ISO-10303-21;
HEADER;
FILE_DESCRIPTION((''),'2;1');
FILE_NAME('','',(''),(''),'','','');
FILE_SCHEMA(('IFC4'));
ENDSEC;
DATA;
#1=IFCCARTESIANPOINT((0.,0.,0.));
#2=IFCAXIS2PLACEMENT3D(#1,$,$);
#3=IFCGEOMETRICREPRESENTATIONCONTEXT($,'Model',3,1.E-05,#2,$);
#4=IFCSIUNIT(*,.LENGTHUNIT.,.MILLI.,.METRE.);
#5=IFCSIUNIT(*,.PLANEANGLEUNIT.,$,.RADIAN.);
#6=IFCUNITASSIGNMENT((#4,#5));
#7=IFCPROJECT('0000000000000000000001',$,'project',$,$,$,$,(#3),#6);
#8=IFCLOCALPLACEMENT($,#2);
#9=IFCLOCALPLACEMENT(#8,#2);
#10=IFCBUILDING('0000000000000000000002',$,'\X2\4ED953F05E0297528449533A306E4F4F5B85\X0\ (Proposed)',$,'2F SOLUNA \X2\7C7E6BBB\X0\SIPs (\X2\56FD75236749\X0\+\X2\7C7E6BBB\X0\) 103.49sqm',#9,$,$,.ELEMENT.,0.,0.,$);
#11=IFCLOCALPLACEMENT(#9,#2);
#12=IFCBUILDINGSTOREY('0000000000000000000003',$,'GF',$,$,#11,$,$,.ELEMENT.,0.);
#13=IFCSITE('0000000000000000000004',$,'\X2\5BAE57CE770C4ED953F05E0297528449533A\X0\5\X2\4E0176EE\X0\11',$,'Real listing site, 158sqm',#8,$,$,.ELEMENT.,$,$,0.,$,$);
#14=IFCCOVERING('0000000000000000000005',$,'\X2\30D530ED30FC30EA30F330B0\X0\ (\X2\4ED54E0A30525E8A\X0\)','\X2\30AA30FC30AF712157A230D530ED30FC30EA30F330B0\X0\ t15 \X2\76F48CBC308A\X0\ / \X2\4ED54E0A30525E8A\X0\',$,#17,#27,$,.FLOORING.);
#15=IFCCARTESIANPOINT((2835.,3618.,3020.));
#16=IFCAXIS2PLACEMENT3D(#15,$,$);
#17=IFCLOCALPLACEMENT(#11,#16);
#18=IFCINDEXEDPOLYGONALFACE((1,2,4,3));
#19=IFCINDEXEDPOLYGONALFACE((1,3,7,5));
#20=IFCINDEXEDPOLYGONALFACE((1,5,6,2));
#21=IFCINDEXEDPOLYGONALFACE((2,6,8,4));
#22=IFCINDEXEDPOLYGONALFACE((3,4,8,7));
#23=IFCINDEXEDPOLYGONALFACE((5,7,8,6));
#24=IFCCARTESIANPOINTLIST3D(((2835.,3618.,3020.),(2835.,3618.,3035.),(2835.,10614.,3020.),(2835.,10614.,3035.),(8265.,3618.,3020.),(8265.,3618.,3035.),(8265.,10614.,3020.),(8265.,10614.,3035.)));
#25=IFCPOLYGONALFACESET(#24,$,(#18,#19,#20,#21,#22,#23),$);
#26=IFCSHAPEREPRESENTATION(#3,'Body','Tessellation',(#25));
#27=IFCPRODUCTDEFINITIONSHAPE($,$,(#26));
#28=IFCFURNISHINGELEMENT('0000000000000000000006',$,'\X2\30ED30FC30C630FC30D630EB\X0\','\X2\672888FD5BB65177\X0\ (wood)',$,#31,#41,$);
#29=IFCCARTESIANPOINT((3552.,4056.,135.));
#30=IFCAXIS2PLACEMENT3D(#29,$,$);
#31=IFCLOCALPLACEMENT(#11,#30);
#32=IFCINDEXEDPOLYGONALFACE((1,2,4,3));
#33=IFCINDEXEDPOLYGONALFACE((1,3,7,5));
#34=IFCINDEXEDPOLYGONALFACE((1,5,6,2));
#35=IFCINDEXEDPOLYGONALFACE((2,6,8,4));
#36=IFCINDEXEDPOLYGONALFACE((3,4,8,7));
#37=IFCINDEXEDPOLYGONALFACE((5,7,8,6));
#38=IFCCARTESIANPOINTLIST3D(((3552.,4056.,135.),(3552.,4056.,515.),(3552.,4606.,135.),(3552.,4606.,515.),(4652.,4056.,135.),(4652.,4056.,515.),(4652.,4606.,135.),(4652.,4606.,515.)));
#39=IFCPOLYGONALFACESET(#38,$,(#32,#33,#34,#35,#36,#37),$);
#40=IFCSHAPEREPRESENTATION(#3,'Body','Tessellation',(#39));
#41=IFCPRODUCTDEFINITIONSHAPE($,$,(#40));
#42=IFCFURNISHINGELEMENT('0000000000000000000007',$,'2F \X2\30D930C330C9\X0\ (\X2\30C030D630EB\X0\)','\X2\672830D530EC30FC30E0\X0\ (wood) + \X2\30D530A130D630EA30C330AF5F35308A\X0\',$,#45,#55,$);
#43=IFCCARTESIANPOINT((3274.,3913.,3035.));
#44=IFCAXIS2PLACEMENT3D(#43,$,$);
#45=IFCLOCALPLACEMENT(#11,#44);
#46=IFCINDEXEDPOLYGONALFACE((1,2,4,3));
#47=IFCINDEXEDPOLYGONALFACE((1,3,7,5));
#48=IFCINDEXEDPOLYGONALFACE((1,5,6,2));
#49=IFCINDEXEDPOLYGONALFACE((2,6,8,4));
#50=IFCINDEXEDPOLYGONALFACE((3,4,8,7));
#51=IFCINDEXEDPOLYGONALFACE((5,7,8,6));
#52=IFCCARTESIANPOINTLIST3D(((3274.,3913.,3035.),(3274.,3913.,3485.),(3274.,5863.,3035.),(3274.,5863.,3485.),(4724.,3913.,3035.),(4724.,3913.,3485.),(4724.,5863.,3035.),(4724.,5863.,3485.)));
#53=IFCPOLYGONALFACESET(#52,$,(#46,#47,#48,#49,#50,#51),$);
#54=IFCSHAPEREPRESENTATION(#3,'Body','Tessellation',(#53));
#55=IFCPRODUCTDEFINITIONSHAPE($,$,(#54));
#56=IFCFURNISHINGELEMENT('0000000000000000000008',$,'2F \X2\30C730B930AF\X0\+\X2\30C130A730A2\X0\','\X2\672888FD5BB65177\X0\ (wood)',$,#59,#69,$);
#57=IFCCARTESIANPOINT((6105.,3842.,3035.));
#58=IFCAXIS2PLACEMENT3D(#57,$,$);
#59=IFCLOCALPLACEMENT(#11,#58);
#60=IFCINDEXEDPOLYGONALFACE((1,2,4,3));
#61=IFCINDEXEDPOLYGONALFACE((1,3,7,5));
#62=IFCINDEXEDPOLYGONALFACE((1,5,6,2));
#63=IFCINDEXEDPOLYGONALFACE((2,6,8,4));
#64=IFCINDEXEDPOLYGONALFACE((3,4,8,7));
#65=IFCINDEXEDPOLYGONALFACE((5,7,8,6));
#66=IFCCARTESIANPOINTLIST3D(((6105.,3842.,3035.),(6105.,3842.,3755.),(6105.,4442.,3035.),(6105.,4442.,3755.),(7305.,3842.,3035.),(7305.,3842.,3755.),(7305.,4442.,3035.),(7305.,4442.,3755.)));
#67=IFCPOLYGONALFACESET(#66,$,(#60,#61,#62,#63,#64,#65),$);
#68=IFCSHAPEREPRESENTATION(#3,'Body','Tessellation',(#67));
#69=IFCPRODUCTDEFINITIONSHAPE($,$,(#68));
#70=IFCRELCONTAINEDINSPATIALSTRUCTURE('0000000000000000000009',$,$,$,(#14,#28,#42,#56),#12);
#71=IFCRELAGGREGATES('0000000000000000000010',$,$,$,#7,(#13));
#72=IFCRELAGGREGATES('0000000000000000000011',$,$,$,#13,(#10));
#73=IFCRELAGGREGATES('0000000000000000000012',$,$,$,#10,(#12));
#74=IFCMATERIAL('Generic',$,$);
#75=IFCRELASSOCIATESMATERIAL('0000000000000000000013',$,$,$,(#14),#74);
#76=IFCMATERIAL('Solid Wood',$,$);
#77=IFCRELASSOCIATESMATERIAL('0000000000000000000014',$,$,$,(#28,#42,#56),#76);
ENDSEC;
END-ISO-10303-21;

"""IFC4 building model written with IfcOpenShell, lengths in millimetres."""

from ifc_helpers import new_model, si_unit, frame, frame_2d, origin, place, context, project, spatial, rectangle, extrude, material, element, save


model = new_model("IFC4")

# Units and contexts
model_context = context("Model", 3, precision=1e-05, world=origin())
ifc_project = project(units=[si_unit("LENGTHUNIT", "METRE", prefix="MILLI"), si_unit("PLANEANGLEUNIT", "RADIAN")], contexts=[model_context])

# Site, building, storey
site_placement = place(None, origin())
site = spatial("IfcSite", under=ifc_project, at=site_placement, Name="宮城県仙台市青葉区5丁目11", ObjectType="Real listing site, 158sqm", CompositionType="ELEMENT", RefElevation=0.0)
building_placement = place(site_placement, origin())
building = spatial("IfcBuilding", under=site, at=building_placement, Name="仙台市青葉区の住宅 (Proposed)", ObjectType="2F SOLUNA 籾殻SIPs (国産杉+籾殻) 103.49sqm", CompositionType="ELEMENT", ElevationOfRefHeight=0.0, ElevationOfTerrain=0.0)
storey_placement = place(building_placement, origin())
storey = spatial("IfcBuildingStorey", under=building, at=storey_placement, Name="GF", CompositionType="ELEMENT", Elevation=0.0)

# Shared definitions
ifc_material_1 = material(Name="Solid Wood")

# Shared definitions
ifc_material_2 = material(Name="Generic")

# Covering
covering_placement = place(storey_placement, frame((2835.0, 3618.0, 3020.0)))
element("IfcCovering", 1, at=covering_placement, inside=storey, material=ifc_material_2, Name="フローリング (仕上げ床)", Description="オーク無垢フローリング t15 直貼り / 仕上げ床", PredefinedType="FLOORING", context=model_context, shape_type="SweptSolid", body=[
    extrude(rectangle(XDim=5430.0, YDim=6996.0, at=frame_2d((2715.0, 3498.0))), frame((2835.0, 3618.0, 3020.0)), (0.0, 0.0, 1.0), 15.0),
])

# Furnishing elements
furnishing_1_placement = place(storey_placement, frame((3552.0, 4056.0, 135.0)))
element("IfcFurnishingElement", 2, at=furnishing_1_placement, inside=storey, material=ifc_material_1, Name="ローテーブル", Description="木製家具 (wood)", context=model_context, shape_type="SweptSolid", body=[
    extrude(rectangle(XDim=1100.0, YDim=550.0, at=frame_2d((550.0, 275.0))), frame((3552.0, 4056.0, 135.0)), (0.0, 0.0, 1.0), 380.0),
])
furnishing_2_placement = place(storey_placement, frame((3274.0, 3913.0, 3035.0)))
element("IfcFurnishingElement", 3, at=furnishing_2_placement, inside=storey, material=ifc_material_1, Name="2F ベッド (ダブル)", Description="木フレーム (wood) + ファブリック張り", context=model_context, shape_type="SweptSolid", body=[
    extrude(rectangle(XDim=1450.0, YDim=1950.0, at=frame_2d((725.0, 975.0))), frame((3274.0, 3913.0, 3035.0)), (0.0, 0.0, 1.0), 450.0),
])
furnishing_3_placement = place(storey_placement, frame((6105.0, 3842.0, 3035.0)))
element("IfcFurnishingElement", 4, at=furnishing_3_placement, inside=storey, material=ifc_material_1, Name="2F デスク+チェア", Description="木製家具 (wood)", context=model_context, shape_type="SweptSolid", body=[
    extrude(rectangle(XDim=1200.0, YDim=600.0, at=frame_2d((600.0, 300.0))), frame((6105.0, 3842.0, 3035.0)), (0.0, 0.0, 1.0), 720.0),
])

save(model, "model.ifc")
